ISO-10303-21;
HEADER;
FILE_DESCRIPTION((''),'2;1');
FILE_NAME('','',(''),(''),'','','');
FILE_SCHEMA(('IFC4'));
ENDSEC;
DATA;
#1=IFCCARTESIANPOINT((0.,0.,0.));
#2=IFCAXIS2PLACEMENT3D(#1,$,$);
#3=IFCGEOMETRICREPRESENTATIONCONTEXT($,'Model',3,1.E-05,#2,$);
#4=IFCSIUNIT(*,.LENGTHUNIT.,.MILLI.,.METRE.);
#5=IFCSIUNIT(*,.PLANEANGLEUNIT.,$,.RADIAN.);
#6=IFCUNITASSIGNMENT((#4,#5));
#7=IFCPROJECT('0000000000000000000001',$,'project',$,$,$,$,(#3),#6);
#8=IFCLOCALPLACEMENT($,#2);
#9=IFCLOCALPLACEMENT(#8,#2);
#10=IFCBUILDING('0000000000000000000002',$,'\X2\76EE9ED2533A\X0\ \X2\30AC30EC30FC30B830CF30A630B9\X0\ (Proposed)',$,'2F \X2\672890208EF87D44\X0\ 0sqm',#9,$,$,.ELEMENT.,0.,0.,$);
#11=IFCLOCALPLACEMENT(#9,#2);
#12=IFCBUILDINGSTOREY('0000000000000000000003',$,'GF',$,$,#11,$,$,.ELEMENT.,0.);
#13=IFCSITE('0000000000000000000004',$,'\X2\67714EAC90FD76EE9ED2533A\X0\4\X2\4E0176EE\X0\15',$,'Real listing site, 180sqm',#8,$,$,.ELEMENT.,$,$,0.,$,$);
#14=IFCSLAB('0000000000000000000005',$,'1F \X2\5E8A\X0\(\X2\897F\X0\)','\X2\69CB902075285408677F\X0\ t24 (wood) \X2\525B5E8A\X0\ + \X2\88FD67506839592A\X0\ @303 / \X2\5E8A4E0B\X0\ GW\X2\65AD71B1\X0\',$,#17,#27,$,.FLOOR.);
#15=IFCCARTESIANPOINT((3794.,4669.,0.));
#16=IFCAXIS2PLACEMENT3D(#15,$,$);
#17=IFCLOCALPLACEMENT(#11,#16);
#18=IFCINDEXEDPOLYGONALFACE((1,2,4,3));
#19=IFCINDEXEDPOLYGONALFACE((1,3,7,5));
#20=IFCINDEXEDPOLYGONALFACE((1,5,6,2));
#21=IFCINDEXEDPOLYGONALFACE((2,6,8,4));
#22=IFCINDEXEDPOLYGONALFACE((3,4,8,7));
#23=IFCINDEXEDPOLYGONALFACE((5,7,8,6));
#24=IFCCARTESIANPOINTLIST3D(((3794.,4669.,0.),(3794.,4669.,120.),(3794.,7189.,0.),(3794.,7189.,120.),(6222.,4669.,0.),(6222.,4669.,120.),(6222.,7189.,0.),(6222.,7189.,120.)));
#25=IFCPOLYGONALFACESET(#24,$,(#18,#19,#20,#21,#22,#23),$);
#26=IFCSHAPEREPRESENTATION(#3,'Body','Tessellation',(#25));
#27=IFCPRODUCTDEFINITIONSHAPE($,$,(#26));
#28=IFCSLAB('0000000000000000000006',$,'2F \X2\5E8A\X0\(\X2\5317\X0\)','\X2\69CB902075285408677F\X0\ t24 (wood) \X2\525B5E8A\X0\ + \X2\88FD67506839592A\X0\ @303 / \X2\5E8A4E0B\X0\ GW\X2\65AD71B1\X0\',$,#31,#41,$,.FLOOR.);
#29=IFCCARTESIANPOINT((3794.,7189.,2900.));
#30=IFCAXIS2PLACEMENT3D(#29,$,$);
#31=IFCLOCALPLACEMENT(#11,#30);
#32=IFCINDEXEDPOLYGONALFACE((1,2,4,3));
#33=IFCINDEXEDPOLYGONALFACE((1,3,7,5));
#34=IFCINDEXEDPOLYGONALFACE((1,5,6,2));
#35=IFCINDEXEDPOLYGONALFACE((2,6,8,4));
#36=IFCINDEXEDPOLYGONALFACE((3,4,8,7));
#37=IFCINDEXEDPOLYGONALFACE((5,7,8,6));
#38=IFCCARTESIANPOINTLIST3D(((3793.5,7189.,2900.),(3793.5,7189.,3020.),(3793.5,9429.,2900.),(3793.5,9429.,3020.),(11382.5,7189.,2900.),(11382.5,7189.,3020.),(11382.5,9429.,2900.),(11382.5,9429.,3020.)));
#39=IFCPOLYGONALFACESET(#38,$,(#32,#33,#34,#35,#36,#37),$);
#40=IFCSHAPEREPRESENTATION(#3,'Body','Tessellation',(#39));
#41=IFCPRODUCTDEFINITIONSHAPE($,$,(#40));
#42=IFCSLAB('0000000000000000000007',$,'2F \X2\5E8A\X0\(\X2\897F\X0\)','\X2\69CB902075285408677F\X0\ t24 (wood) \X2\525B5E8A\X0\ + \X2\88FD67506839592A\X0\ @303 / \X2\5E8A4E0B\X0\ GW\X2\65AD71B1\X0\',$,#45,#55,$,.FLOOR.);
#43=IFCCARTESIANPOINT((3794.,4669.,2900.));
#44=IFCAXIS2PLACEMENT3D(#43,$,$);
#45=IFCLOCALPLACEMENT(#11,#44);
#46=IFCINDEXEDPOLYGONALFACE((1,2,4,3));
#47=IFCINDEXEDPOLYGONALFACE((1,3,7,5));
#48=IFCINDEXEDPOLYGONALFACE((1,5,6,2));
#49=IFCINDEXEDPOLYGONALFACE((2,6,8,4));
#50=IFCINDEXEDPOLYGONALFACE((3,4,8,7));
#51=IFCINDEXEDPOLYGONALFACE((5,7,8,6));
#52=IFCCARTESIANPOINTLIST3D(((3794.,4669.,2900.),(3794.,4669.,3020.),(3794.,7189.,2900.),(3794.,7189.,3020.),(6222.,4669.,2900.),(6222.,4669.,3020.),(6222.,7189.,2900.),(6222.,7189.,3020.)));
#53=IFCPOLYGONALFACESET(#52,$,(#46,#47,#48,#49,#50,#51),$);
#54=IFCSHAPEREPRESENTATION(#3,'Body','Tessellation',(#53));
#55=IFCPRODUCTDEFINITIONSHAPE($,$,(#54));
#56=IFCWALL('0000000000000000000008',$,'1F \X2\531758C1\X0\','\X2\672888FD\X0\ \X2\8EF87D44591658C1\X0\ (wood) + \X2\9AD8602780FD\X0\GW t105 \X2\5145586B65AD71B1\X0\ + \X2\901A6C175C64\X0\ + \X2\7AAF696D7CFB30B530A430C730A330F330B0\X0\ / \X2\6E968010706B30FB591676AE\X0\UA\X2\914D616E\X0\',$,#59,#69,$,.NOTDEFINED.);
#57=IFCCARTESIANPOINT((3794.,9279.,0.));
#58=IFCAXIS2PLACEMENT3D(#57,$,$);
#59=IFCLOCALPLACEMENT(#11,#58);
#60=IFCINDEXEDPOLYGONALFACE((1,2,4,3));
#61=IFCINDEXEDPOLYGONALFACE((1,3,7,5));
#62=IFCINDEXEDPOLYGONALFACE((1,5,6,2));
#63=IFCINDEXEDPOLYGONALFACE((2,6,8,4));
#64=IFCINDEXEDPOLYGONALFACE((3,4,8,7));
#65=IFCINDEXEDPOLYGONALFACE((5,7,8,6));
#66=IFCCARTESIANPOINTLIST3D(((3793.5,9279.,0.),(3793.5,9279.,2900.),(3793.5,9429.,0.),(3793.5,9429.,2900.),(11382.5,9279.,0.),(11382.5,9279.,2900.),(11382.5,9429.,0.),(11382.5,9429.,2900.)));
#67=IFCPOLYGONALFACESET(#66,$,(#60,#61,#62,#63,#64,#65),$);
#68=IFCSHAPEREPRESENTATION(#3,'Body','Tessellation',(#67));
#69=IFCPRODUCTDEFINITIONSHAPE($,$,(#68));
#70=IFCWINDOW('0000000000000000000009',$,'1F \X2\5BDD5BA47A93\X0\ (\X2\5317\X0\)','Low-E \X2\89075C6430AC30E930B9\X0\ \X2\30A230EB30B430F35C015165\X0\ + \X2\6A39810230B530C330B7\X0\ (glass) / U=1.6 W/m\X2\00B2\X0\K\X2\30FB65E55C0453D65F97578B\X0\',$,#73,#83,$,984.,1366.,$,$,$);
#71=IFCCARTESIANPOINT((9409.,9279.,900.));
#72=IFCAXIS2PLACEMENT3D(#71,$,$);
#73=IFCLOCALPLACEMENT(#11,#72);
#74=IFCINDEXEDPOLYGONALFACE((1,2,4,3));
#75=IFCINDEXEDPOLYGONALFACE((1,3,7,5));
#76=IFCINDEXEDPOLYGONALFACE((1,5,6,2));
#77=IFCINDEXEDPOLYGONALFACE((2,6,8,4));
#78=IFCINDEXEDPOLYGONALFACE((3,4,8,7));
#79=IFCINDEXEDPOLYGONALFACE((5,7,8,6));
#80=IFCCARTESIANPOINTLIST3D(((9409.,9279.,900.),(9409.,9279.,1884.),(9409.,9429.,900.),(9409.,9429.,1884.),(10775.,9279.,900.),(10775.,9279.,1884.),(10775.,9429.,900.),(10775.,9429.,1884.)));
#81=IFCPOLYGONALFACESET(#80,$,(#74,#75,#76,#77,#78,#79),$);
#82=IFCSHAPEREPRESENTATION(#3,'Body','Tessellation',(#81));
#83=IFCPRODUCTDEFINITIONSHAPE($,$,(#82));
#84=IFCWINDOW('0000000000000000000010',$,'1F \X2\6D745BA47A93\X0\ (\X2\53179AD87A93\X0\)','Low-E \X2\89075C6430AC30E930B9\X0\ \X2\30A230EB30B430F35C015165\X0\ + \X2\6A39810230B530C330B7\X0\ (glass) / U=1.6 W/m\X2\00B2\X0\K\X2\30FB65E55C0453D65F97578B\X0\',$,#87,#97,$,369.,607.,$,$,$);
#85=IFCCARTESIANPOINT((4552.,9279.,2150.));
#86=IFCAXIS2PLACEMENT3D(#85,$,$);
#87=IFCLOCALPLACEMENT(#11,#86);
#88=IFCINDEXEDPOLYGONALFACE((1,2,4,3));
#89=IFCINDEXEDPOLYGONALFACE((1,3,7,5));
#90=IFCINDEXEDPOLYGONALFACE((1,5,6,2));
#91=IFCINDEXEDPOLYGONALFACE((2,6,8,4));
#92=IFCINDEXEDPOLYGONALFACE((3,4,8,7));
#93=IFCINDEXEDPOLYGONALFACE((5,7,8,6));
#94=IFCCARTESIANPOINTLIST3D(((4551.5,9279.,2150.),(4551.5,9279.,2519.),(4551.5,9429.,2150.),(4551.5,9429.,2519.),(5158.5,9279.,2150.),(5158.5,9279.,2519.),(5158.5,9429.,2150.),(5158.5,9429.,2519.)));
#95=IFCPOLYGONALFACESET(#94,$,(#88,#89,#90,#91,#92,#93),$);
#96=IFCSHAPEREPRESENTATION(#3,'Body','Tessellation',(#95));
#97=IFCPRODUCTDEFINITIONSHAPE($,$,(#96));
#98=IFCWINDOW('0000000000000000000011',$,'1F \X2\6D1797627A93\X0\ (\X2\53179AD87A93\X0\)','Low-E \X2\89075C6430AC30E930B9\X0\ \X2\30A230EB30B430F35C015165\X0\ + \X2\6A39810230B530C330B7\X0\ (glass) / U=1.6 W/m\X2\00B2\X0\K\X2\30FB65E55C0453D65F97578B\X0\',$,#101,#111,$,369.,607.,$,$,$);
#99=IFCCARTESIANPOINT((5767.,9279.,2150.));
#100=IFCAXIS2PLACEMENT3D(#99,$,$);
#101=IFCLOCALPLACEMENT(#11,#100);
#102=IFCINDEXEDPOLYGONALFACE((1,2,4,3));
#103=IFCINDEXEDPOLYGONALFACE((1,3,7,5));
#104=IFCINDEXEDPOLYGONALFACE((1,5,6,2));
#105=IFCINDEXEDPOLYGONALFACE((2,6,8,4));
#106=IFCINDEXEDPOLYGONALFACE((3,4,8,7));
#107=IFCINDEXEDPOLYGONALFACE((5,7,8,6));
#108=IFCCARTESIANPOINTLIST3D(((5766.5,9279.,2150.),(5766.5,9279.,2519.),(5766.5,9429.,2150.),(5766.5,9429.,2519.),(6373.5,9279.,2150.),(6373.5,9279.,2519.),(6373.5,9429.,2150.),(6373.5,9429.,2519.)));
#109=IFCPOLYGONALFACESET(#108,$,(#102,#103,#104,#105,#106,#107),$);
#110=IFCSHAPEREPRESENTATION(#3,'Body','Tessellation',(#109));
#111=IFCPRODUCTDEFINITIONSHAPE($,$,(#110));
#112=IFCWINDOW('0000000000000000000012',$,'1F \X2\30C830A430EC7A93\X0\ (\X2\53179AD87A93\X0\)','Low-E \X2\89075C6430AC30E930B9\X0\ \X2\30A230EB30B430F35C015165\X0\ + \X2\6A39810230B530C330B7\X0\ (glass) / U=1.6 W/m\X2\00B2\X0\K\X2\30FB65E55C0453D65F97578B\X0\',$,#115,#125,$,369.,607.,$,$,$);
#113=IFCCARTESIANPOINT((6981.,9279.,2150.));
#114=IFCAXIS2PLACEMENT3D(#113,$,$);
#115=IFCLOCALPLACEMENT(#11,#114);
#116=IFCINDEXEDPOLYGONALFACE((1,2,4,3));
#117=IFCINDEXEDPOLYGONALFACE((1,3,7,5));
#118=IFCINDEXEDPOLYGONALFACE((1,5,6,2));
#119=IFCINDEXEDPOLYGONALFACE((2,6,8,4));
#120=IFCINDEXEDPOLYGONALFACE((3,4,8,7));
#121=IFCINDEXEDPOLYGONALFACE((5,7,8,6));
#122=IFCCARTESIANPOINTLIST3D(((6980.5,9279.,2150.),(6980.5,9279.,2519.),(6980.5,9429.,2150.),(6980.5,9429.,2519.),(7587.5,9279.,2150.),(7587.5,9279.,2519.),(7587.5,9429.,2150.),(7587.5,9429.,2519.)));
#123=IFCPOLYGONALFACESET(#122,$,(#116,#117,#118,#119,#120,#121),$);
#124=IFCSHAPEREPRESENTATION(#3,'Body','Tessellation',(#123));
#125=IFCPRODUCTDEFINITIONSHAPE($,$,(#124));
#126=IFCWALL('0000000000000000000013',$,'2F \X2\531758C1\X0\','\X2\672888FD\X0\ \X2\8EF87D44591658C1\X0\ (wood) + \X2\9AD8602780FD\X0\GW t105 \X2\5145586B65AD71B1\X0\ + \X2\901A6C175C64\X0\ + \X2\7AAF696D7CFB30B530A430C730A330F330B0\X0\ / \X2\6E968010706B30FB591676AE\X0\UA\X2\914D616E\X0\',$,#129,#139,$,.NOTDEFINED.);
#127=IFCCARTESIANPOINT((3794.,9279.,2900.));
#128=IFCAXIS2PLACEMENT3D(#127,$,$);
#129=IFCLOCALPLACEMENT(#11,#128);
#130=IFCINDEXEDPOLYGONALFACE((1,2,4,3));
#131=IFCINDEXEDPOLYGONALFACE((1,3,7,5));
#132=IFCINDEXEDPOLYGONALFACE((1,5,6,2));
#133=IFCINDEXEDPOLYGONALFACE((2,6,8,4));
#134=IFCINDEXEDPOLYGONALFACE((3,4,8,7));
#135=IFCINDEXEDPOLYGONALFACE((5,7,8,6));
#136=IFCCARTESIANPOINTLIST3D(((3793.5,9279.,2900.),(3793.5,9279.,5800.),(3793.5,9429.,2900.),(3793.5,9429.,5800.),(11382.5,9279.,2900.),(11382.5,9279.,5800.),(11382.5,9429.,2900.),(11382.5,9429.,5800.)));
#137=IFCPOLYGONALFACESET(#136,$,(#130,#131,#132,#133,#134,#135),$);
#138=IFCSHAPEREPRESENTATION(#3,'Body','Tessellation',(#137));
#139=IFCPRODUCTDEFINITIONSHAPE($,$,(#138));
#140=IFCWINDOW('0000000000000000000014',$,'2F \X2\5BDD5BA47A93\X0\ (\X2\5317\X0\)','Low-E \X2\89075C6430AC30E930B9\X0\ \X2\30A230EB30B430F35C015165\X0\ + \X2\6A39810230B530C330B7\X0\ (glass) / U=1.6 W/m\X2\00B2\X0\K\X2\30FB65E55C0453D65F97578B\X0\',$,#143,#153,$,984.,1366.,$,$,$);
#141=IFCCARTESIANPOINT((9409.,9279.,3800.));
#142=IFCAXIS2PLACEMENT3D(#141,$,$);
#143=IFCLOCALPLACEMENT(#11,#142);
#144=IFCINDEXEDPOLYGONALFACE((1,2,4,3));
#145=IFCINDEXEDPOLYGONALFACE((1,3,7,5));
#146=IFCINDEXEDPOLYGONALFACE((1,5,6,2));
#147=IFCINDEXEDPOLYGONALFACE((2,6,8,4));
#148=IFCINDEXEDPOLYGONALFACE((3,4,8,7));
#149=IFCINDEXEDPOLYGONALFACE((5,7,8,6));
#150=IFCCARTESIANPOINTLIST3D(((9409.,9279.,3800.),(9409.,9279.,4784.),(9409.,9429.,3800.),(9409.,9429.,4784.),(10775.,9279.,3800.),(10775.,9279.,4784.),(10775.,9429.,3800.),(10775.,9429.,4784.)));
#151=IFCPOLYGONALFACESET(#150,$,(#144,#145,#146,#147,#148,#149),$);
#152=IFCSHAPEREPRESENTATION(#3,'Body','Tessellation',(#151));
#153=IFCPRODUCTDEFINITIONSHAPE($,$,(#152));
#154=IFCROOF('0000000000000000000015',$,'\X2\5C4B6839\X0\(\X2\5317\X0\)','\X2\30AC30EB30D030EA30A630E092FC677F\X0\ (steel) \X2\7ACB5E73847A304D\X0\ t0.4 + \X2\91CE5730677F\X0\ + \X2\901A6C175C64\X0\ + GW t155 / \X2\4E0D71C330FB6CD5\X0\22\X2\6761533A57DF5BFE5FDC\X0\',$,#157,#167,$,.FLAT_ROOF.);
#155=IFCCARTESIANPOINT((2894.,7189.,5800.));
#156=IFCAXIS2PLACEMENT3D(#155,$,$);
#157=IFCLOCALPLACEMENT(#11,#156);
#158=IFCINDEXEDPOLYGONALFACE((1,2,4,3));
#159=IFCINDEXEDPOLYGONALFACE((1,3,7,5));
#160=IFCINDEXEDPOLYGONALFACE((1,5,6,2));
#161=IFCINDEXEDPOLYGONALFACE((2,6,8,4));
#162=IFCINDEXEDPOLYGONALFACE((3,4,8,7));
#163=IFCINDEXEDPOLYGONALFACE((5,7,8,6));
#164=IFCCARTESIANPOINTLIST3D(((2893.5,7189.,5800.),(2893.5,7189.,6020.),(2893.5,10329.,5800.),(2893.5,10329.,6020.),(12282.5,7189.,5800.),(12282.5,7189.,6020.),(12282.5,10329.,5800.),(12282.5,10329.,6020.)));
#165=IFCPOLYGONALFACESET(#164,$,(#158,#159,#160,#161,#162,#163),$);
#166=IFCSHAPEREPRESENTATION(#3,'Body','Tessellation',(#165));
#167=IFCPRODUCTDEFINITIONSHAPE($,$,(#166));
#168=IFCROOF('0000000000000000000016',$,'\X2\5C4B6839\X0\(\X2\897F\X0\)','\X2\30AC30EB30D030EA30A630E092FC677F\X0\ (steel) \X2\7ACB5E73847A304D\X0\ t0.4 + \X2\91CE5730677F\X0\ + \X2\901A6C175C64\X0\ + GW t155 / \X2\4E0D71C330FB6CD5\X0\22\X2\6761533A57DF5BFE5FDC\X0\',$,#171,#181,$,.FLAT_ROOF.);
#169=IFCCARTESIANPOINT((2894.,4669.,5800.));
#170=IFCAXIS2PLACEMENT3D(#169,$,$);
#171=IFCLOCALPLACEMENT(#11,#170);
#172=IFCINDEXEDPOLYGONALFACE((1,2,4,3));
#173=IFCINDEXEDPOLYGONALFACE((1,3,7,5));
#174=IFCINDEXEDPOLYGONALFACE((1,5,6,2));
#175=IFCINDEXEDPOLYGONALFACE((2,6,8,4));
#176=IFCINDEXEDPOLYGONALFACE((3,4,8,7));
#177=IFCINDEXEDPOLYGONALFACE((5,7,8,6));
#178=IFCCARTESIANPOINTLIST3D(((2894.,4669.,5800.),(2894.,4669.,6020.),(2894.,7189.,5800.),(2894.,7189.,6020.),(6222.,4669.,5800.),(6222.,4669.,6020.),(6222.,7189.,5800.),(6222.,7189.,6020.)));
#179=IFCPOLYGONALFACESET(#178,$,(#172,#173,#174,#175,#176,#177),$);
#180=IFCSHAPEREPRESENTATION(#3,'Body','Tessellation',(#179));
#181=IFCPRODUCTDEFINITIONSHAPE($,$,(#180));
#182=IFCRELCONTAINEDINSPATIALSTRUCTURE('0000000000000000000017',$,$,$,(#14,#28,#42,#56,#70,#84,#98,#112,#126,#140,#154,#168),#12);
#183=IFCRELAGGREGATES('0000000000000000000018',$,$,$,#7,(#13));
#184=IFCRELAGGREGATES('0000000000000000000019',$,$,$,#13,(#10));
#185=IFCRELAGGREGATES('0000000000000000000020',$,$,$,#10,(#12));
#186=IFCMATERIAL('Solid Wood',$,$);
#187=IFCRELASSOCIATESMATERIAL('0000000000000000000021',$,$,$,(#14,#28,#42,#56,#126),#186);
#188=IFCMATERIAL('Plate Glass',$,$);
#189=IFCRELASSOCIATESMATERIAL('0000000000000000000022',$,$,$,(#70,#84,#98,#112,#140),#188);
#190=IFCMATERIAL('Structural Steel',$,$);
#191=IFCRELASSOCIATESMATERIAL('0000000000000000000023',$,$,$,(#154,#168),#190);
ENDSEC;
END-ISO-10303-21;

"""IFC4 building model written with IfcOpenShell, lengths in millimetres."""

from ifc_helpers import new_model, si_unit, frame, frame_2d, origin, place, context, project, spatial, rectangle, extrude, material, element, fill, save


model = new_model("IFC4")

# Units and contexts
model_context = context("Model", 3, precision=1e-05, world=origin())
ifc_project = project(units=[si_unit("LENGTHUNIT", "METRE", prefix="MILLI"), si_unit("PLANEANGLEUNIT", "RADIAN")], contexts=[model_context])

# Site, building, storey
site_placement = place(None, origin())
site = spatial("IfcSite", under=ifc_project, at=site_placement, Name="東京都目黒区4丁目15", ObjectType="Real listing site, 180sqm", CompositionType="ELEMENT", RefElevation=0.0)
building_placement = place(site_placement, origin())
building = spatial("IfcBuilding", under=site, at=building_placement, Name="目黒区 ガレージハウス (Proposed)", ObjectType="2F 木造軸組 0sqm", CompositionType="ELEMENT", ElevationOfRefHeight=0.0, ElevationOfTerrain=0.0)
storey_placement = place(building_placement, origin())
storey = spatial("IfcBuildingStorey", under=building, at=storey_placement, Name="GF", CompositionType="ELEMENT", Elevation=0.0)

# Slabs
ifc_material_1 = material(Name="Solid Wood")
slab_1_placement = place(storey_placement, frame((3794.0, 4669.0, 0.0)))
element("IfcSlab", 1, at=slab_1_placement, inside=storey, material=ifc_material_1, Name="1F 床(西)", Description="構造用合板 t24 (wood) 剛床 + 製材根太 @303 / 床下 GW断熱", PredefinedType="FLOOR", context=model_context, shape_type="SweptSolid", body=[
    extrude(rectangle(XDim=2428.0, YDim=2520.0, at=frame_2d((1214.0, 1260.0))), frame((3794.0, 4669.0, 0.0)), (0.0, 0.0, 1.0), 120.0),
])
slab_2_placement = place(storey_placement, frame((3794.0, 7189.0, 2900.0)))
element("IfcSlab", 2, at=slab_2_placement, inside=storey, material=ifc_material_1, Name="2F 床(北)", Description="構造用合板 t24 (wood) 剛床 + 製材根太 @303 / 床下 GW断熱", PredefinedType="FLOOR", context=model_context, shape_type="SweptSolid", body=[
    extrude(rectangle(XDim=7589.0, YDim=2240.0, at=frame_2d((3794.0, 1120.0))), frame((3794.0, 7189.0, 2900.0)), (0.0, 0.0, 1.0), 120.0),
])
slab_3_placement = place(storey_placement, frame((3794.0, 4669.0, 2900.0)))
element("IfcSlab", 3, at=slab_3_placement, inside=storey, material=ifc_material_1, Name="2F 床(西)", Description="構造用合板 t24 (wood) 剛床 + 製材根太 @303 / 床下 GW断熱", PredefinedType="FLOOR", context=model_context, shape_type="SweptSolid", body=[
    extrude(rectangle(XDim=2428.0, YDim=2520.0, at=frame_2d((1214.0, 1260.0))), frame((3794.0, 4669.0, 2900.0)), (0.0, 0.0, 1.0), 120.0),
])

# Wall, openings, windows
wall_1_placement = place(storey_placement, frame((3794.0, 9279.0, 0.0)))
wall_1 = element("IfcWall", 4, at=wall_1_placement, inside=storey, material=ifc_material_1, Name="1F 北壁", Description="木製 軸組外壁 (wood) + 高性能GW t105 充填断熱 + 通気層 + 窯業系サイディング / 準耐火・外皮UA配慮", PredefinedType="NOTDEFINED", context=model_context, shape_type="SweptSolid", body=[
    extrude(rectangle(XDim=7589.0, YDim=150.0, at=frame_2d((3794.0, 75.0))), frame((3794.0, 9279.0, 0.0)), (0.0, 0.0, 1.0), 2900.0),
])
opening_1_placement = place(storey_placement, frame((9409.0, 9279.0, 900.0)))
opening_1 = element("IfcOpeningElement", 5, at=opening_1_placement, cuts=wall_1, PredefinedType="NOTDEFINED", context=model_context, shape_type="SweptSolid", body=[
    extrude(rectangle(XDim=1366.0, YDim=150.0, at=frame_2d((683.0, 75.0))), frame((9409.0, 9279.0, 900.0)), (0.0, 0.0, 1.0), 984.0),
])
opening_2_placement = place(storey_placement, frame((4552.0, 9279.0, 2150.0)))
opening_2 = element("IfcOpeningElement", 6, at=opening_2_placement, cuts=wall_1, PredefinedType="NOTDEFINED", context=model_context, shape_type="SweptSolid", body=[
    extrude(rectangle(XDim=607.0, YDim=150.0, at=frame_2d((303.0, 75.0))), frame((4552.0, 9279.0, 2150.0)), (0.0, 0.0, 1.0), 369.0),
])
opening_3_placement = place(storey_placement, frame((5767.0, 9279.0, 2150.0)))
opening_3 = element("IfcOpeningElement", 7, at=opening_3_placement, cuts=wall_1, PredefinedType="NOTDEFINED", context=model_context, shape_type="SweptSolid", body=[
    extrude(rectangle(XDim=607.0, YDim=150.0, at=frame_2d((303.0, 75.0))), frame((5767.0, 9279.0, 2150.0)), (0.0, 0.0, 1.0), 369.0),
])
opening_4_placement = place(storey_placement, frame((6981.0, 9279.0, 2150.0)))
opening_4 = element("IfcOpeningElement", 8, at=opening_4_placement, cuts=wall_1, PredefinedType="NOTDEFINED", context=model_context, shape_type="SweptSolid", body=[
    extrude(rectangle(XDim=607.0, YDim=150.0, at=frame_2d((303.0, 75.0))), frame((6981.0, 9279.0, 2150.0)), (0.0, 0.0, 1.0), 369.0),
])
ifc_material_2 = material(Name="Plate Glass")
window_1_placement = place(storey_placement, frame((9409.0, 9279.0, 900.0)))
window_1 = element("IfcWindow", 9, at=window_1_placement, inside=storey, material=ifc_material_2, Name="1F 寝室窓 (北)", Description="Low-E 複層ガラス アルゴン封入 + 樹脂サッシ (glass) / U=1.6 W/m²K・日射取得型", OverallHeight=984.0, OverallWidth=1366.0, context=model_context, shape_type="SweptSolid", body=[
    extrude(rectangle(XDim=1366.0, YDim=150.0, at=frame_2d((683.0, 75.0))), frame((9409.0, 9279.0, 900.0)), (0.0, 0.0, 1.0), 984.0),
])
fill(opening_1, window_1)
window_2_placement = place(storey_placement, frame((4552.0, 9279.0, 2150.0)))
window_2 = element("IfcWindow", 10, at=window_2_placement, inside=storey, material=ifc_material_2, Name="1F 浴室窓 (北高窓)", Description="Low-E 複層ガラス アルゴン封入 + 樹脂サッシ (glass) / U=1.6 W/m²K・日射取得型", OverallHeight=369.0, OverallWidth=607.0, context=model_context, shape_type="SweptSolid", body=[
    extrude(rectangle(XDim=607.0, YDim=150.0, at=frame_2d((303.0, 75.0))), frame((4552.0, 9279.0, 2150.0)), (0.0, 0.0, 1.0), 369.0),
])
fill(opening_2, window_2)
window_3_placement = place(storey_placement, frame((5767.0, 9279.0, 2150.0)))
window_3 = element("IfcWindow", 11, at=window_3_placement, inside=storey, material=ifc_material_2, Name="1F 洗面窓 (北高窓)", Description="Low-E 複層ガラス アルゴン封入 + 樹脂サッシ (glass) / U=1.6 W/m²K・日射取得型", OverallHeight=369.0, OverallWidth=607.0, context=model_context, shape_type="SweptSolid", body=[
    extrude(rectangle(XDim=607.0, YDim=150.0, at=frame_2d((303.0, 75.0))), frame((5767.0, 9279.0, 2150.0)), (0.0, 0.0, 1.0), 369.0),
])
fill(opening_3, window_3)
window_4_placement = place(storey_placement, frame((6981.0, 9279.0, 2150.0)))
window_4 = element("IfcWindow", 12, at=window_4_placement, inside=storey, material=ifc_material_2, Name="1F トイレ窓 (北高窓)", Description="Low-E 複層ガラス アルゴン封入 + 樹脂サッシ (glass) / U=1.6 W/m²K・日射取得型", OverallHeight=369.0, OverallWidth=607.0, context=model_context, shape_type="SweptSolid", body=[
    extrude(rectangle(XDim=607.0, YDim=150.0, at=frame_2d((303.0, 75.0))), frame((6981.0, 9279.0, 2150.0)), (0.0, 0.0, 1.0), 369.0),
])
fill(opening_4, window_4)

# Wall, opening, window
wall_2_placement = place(storey_placement, frame((3794.0, 9279.0, 2900.0)))
wall_2 = element("IfcWall", 13, at=wall_2_placement, inside=storey, material=ifc_material_1, Name="2F 北壁", Description="木製 軸組外壁 (wood) + 高性能GW t105 充填断熱 + 通気層 + 窯業系サイディング / 準耐火・外皮UA配慮", PredefinedType="NOTDEFINED", context=model_context, shape_type="SweptSolid", body=[
    extrude(rectangle(XDim=7589.0, YDim=150.0, at=frame_2d((3794.0, 75.0))), frame((3794.0, 9279.0, 2900.0)), (0.0, 0.0, 1.0), 2900.0),
])
opening_5_placement = place(storey_placement, frame((9409.0, 9279.0, 3800.0)))
opening_5 = element("IfcOpeningElement", 14, at=opening_5_placement, cuts=wall_2, PredefinedType="NOTDEFINED", context=model_context, shape_type="SweptSolid", body=[
    extrude(rectangle(XDim=1366.0, YDim=150.0, at=frame_2d((683.0, 75.0))), frame((9409.0, 9279.0, 3800.0)), (0.0, 0.0, 1.0), 984.0),
])
window_5_placement = place(storey_placement, frame((9409.0, 9279.0, 3800.0)))
window_5 = element("IfcWindow", 15, at=window_5_placement, inside=storey, material=ifc_material_2, Name="2F 寝室窓 (北)", Description="Low-E 複層ガラス アルゴン封入 + 樹脂サッシ (glass) / U=1.6 W/m²K・日射取得型", OverallHeight=984.0, OverallWidth=1366.0, context=model_context, shape_type="SweptSolid", body=[
    extrude(rectangle(XDim=1366.0, YDim=150.0, at=frame_2d((683.0, 75.0))), frame((9409.0, 9279.0, 3800.0)), (0.0, 0.0, 1.0), 984.0),
])
fill(opening_5, window_5)

# Roofs
ifc_material_3 = material(Name="Structural Steel")
for number, where, name in (
    (16, (2894.0, 7189.0, 5800.0), "屋根(北)"),
):
    element("IfcRoof", number, at=place(storey_placement, frame(where)), inside=storey, material=ifc_material_3, Name=name, Description="ガルバリウム鋼板 (steel) 立平葺き t0.4 + 野地板 + 通気層 + GW t155 / 不燃・法22条区域対応", PredefinedType="FLAT_ROOF", context=model_context, shape_type="SweptSolid", body=[
        extrude(rectangle(XDim=9389.0, YDim=3140.0, at=frame_2d((4694.0, 1570.0))), frame((2894.0, 7189.0, 5800.0)), (0.0, 0.0, 1.0), 220.0),
    ])
roof_placement = place(storey_placement, frame((2894.0, 4669.0, 5800.0)))
element("IfcRoof", 17, at=roof_placement, inside=storey, material=ifc_material_3, Name="屋根(西)", Description="ガルバリウム鋼板 (steel) 立平葺き t0.4 + 野地板 + 通気層 + GW t155 / 不燃・法22条区域対応", PredefinedType="FLAT_ROOF", context=model_context, shape_type="SweptSolid", body=[
    extrude(rectangle(XDim=3328.0, YDim=2520.0, at=frame_2d((1664.0, 1260.0))), frame((2894.0, 4669.0, 5800.0)), (0.0, 0.0, 1.0), 220.0),
])

save(model, "model.ifc")
